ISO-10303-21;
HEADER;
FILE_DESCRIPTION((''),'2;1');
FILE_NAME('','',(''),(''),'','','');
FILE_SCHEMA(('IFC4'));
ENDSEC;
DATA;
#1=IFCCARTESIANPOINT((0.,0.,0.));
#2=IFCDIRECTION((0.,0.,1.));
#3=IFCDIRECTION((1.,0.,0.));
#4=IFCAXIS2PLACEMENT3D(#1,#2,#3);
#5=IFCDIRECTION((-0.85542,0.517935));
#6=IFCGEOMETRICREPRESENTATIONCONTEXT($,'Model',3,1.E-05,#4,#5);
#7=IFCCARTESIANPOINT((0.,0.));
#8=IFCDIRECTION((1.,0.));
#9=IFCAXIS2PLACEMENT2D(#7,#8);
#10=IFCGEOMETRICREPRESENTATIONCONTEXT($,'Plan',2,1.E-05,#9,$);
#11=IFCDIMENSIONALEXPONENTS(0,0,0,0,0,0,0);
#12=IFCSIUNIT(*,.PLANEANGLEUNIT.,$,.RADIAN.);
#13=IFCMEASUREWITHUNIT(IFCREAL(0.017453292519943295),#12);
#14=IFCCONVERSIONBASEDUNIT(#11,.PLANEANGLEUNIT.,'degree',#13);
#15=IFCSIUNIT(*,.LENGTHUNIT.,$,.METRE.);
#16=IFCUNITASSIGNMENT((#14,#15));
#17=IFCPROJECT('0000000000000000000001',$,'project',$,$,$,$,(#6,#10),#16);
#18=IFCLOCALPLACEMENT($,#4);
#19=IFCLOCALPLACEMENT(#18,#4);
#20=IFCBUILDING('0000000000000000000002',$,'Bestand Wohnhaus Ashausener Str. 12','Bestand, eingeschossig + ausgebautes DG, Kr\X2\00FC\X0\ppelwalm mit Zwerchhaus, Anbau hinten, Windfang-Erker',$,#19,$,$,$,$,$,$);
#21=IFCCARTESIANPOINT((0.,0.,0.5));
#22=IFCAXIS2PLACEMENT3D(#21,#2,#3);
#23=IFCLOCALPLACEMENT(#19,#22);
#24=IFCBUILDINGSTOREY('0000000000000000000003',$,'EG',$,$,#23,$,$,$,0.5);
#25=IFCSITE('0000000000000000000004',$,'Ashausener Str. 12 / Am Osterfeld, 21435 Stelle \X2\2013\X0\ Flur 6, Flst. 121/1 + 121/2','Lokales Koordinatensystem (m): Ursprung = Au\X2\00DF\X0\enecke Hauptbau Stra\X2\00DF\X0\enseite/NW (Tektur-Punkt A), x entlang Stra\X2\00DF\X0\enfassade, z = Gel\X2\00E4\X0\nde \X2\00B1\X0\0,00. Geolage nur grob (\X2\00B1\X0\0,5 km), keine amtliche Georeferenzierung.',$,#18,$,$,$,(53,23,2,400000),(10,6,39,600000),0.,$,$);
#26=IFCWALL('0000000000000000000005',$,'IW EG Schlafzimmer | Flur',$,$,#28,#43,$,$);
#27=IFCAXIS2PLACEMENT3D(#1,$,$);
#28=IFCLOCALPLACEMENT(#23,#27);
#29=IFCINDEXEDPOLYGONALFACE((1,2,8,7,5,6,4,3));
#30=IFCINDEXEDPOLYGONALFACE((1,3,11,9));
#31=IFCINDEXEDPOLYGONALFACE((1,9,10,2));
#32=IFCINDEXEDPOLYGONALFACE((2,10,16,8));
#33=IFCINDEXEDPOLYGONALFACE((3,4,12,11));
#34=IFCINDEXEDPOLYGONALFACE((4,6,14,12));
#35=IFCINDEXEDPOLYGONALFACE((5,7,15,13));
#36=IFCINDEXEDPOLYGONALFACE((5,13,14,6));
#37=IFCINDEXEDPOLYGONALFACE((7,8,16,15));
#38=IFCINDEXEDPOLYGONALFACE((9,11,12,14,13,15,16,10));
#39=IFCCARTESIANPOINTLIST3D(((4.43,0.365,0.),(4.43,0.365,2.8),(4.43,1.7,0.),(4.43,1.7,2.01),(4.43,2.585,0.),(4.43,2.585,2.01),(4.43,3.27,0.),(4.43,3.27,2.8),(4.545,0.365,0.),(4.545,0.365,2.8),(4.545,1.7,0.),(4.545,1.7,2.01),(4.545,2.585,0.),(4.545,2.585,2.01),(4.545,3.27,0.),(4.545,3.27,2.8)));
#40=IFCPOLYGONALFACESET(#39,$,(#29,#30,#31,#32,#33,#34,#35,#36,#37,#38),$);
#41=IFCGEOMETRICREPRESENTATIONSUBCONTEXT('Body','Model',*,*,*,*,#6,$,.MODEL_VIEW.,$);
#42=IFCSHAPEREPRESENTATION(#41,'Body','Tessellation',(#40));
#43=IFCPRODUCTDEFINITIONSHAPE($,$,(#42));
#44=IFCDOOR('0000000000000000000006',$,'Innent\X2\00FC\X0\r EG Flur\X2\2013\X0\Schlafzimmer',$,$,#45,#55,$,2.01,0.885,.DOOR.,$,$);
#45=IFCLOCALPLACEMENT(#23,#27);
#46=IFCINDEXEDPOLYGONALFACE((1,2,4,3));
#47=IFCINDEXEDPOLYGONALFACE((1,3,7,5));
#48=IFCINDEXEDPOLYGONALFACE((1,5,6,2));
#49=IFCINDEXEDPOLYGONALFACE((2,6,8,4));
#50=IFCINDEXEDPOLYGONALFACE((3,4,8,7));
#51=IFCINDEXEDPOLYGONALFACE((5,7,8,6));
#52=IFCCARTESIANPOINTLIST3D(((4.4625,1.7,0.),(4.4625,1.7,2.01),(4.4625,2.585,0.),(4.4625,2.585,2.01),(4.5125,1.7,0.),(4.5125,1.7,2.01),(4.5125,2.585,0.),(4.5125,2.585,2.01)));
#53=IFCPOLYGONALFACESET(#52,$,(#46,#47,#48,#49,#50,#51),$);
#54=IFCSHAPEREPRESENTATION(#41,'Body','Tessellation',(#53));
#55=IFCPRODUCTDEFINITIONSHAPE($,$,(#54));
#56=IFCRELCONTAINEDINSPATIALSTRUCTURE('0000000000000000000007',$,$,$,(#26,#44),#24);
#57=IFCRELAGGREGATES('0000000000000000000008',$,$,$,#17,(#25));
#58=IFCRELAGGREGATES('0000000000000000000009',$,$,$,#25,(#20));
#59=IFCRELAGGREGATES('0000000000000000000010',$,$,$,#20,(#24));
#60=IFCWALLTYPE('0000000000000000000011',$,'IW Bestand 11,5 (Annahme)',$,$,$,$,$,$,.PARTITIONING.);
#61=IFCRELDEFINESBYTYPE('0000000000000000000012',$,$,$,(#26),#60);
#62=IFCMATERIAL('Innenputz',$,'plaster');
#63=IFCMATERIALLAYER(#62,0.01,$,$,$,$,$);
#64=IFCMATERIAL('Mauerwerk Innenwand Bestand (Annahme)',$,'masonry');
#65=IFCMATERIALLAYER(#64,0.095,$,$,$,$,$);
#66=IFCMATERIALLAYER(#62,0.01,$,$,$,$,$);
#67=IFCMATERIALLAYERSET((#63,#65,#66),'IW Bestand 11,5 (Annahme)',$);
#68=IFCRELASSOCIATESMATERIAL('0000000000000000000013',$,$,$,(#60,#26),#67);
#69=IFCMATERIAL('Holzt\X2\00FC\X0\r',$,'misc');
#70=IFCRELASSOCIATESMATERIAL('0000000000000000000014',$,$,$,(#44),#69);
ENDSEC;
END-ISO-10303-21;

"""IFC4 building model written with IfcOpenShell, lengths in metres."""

from ifc_helpers import new_model, entity, si_unit, converted_unit, direction, frame, origin_with_axes, origin_2d_with_axis, place, context, subcontext, project, spatial, indexed_curve, outline, extrude, material, layer, layer_set, layer_usage, type_object, element, fill, save


model = new_model("IFC4")

# Units and contexts
model_context = context("Model", 3, precision=1e-05, world=origin_with_axes(), true_north=direction((-0.85542, 0.517935)))
plan_context = context("Plan", 2, precision=1e-05, world=origin_2d_with_axis())
body_context = subcontext(model_context, "Body", "Model", "MODEL_VIEW")
ifc_project = project(units=[converted_unit("PLANEANGLEUNIT", "degree", entity("IfcReal", 0.017453292519943295), si_unit("PLANEANGLEUNIT", "RADIAN"), dimensions=[0, 0, 0, 0, 0, 0, 0]), si_unit("LENGTHUNIT", "METRE")], contexts=[model_context, plan_context])

# Site, building, storey
site_placement = place(None, origin_with_axes())
site = spatial("IfcSite", under=ifc_project, at=site_placement, Name="Ashausener Str. 12 / Am Osterfeld, 21435 Stelle – Flur 6, Flst. 121/1 + 121/2", Description="Lokales Koordinatensystem (m): Ursprung = Außenecke Hauptbau Straßenseite/NW (Tektur-Punkt A), x entlang Straßenfassade, z = Gelände ±0,00. Geolage nur grob (±0,5 km), keine amtliche Georeferenzierung.", RefLatitude=(53, 23, 2, 400000), RefLongitude=(10, 6, 39, 600000), RefElevation=0.0)
building_placement = place(site_placement, origin_with_axes())
building = spatial("IfcBuilding", under=site, at=building_placement, Name="Bestand Wohnhaus Ashausener Str. 12", Description="Bestand, eingeschossig + ausgebautes DG, Krüppelwalm mit Zwerchhaus, Anbau hinten, Windfang-Erker")
storey_placement = place(building_placement, frame((0.0, 0.0, 0.5), z_axis=(0.0, 0.0, 1.0), x_axis=(1.0, 0.0, 0.0)))
storey = spatial("IfcBuildingStorey", under=building, at=storey_placement, Name="EG", Elevation=0.5)

# Shared definitions
ifc_material_1 = material(Name="Holztür", Category="misc")

# Shared definitions
ifc_material_2 = material(Name="Innenputz", Category="plaster")
ifc_layer_1 = layer(ifc_material_2, 0.01)
ifc_material_3 = material(Name="Mauerwerk Innenwand Bestand (Annahme)", Category="masonry")
ifc_layer_2 = layer(ifc_material_3, 0.095)
ifc_layer_3 = layer(ifc_material_2, 0.01)
ifc_layer_set_1 = layer_set([ifc_layer_1, ifc_layer_2, ifc_layer_3], Name="IW Bestand 11,5 (Annahme)")
wall_type_1 = type_object("IfcWallType", Name="IW Bestand 11,5 (Annahme)", PredefinedType="PARTITIONING", material=ifc_layer_set_1)

# Wall, opening, door
ifc_layer_usage_1 = layer_usage(ifc_layer_set_1, "AXIS2", "POSITIVE", 0.0)
wall_1_placement = place(storey_placement, frame((4.43, 3.27, 0.0), z_axis=(0.0, 0.0, 1.0), x_axis=(0.0, -1.0, 0.0)))
wall_1 = element("IfcWall", 1, at=wall_1_placement, inside=storey, type_object=wall_type_1, material=ifc_layer_usage_1, Name="IW EG Schlafzimmer | Flur", context=body_context, shape_type="SweptSolid", body=[
    extrude(outline(indexed_curve([(0.0, 0.0), (0.0, 0.115), (2.905, 0.115), (2.905, 0.0), (0.0, 0.0)], self_intersect=False)), origin_with_axes(), (0.0, 0.0, 1.0), 2.8),
])
opening_1_placement = place(wall_1_placement, frame((0.685, -0.1, 0.0), z_axis=(0.0, 0.0, 1.0), x_axis=(1.0, 0.0, 0.0)))
opening_1 = element("IfcOpeningElement", 2, at=opening_1_placement, cuts=wall_1, context=body_context, shape_type="SweptSolid", body=[
    extrude(outline(indexed_curve([(0.0, 0.0), (0.0, 0.315), (0.885, 0.315), (0.885, 0.0), (0.0, 0.0)], self_intersect=False)), origin_with_axes(), (0.0, 0.0, 1.0), 2.01),
])
door_1_placement = place(storey_placement, frame((4.4625, 2.585, 0.0), z_axis=(0.0, 0.0, 1.0), x_axis=(0.0, -1.0, 0.0)))
door_1 = element("IfcDoor", 3, at=door_1_placement, inside=storey, material=ifc_material_1, Name="Innentür EG Flur–Schlafzimmer", OverallHeight=2.01, OverallWidth=0.885, PredefinedType="DOOR", context=body_context, shape_type="SweptSolid", body=[
    extrude(outline(indexed_curve([(0.0, 0.0), (0.0, 0.05), (0.885, 0.05), (0.885, 0.0), (0.0, 0.0)], self_intersect=False)), origin_with_axes(), (0.0, 0.0, 1.0), 2.01),
])
fill(opening_1, door_1)

save(model, "model.ifc")
